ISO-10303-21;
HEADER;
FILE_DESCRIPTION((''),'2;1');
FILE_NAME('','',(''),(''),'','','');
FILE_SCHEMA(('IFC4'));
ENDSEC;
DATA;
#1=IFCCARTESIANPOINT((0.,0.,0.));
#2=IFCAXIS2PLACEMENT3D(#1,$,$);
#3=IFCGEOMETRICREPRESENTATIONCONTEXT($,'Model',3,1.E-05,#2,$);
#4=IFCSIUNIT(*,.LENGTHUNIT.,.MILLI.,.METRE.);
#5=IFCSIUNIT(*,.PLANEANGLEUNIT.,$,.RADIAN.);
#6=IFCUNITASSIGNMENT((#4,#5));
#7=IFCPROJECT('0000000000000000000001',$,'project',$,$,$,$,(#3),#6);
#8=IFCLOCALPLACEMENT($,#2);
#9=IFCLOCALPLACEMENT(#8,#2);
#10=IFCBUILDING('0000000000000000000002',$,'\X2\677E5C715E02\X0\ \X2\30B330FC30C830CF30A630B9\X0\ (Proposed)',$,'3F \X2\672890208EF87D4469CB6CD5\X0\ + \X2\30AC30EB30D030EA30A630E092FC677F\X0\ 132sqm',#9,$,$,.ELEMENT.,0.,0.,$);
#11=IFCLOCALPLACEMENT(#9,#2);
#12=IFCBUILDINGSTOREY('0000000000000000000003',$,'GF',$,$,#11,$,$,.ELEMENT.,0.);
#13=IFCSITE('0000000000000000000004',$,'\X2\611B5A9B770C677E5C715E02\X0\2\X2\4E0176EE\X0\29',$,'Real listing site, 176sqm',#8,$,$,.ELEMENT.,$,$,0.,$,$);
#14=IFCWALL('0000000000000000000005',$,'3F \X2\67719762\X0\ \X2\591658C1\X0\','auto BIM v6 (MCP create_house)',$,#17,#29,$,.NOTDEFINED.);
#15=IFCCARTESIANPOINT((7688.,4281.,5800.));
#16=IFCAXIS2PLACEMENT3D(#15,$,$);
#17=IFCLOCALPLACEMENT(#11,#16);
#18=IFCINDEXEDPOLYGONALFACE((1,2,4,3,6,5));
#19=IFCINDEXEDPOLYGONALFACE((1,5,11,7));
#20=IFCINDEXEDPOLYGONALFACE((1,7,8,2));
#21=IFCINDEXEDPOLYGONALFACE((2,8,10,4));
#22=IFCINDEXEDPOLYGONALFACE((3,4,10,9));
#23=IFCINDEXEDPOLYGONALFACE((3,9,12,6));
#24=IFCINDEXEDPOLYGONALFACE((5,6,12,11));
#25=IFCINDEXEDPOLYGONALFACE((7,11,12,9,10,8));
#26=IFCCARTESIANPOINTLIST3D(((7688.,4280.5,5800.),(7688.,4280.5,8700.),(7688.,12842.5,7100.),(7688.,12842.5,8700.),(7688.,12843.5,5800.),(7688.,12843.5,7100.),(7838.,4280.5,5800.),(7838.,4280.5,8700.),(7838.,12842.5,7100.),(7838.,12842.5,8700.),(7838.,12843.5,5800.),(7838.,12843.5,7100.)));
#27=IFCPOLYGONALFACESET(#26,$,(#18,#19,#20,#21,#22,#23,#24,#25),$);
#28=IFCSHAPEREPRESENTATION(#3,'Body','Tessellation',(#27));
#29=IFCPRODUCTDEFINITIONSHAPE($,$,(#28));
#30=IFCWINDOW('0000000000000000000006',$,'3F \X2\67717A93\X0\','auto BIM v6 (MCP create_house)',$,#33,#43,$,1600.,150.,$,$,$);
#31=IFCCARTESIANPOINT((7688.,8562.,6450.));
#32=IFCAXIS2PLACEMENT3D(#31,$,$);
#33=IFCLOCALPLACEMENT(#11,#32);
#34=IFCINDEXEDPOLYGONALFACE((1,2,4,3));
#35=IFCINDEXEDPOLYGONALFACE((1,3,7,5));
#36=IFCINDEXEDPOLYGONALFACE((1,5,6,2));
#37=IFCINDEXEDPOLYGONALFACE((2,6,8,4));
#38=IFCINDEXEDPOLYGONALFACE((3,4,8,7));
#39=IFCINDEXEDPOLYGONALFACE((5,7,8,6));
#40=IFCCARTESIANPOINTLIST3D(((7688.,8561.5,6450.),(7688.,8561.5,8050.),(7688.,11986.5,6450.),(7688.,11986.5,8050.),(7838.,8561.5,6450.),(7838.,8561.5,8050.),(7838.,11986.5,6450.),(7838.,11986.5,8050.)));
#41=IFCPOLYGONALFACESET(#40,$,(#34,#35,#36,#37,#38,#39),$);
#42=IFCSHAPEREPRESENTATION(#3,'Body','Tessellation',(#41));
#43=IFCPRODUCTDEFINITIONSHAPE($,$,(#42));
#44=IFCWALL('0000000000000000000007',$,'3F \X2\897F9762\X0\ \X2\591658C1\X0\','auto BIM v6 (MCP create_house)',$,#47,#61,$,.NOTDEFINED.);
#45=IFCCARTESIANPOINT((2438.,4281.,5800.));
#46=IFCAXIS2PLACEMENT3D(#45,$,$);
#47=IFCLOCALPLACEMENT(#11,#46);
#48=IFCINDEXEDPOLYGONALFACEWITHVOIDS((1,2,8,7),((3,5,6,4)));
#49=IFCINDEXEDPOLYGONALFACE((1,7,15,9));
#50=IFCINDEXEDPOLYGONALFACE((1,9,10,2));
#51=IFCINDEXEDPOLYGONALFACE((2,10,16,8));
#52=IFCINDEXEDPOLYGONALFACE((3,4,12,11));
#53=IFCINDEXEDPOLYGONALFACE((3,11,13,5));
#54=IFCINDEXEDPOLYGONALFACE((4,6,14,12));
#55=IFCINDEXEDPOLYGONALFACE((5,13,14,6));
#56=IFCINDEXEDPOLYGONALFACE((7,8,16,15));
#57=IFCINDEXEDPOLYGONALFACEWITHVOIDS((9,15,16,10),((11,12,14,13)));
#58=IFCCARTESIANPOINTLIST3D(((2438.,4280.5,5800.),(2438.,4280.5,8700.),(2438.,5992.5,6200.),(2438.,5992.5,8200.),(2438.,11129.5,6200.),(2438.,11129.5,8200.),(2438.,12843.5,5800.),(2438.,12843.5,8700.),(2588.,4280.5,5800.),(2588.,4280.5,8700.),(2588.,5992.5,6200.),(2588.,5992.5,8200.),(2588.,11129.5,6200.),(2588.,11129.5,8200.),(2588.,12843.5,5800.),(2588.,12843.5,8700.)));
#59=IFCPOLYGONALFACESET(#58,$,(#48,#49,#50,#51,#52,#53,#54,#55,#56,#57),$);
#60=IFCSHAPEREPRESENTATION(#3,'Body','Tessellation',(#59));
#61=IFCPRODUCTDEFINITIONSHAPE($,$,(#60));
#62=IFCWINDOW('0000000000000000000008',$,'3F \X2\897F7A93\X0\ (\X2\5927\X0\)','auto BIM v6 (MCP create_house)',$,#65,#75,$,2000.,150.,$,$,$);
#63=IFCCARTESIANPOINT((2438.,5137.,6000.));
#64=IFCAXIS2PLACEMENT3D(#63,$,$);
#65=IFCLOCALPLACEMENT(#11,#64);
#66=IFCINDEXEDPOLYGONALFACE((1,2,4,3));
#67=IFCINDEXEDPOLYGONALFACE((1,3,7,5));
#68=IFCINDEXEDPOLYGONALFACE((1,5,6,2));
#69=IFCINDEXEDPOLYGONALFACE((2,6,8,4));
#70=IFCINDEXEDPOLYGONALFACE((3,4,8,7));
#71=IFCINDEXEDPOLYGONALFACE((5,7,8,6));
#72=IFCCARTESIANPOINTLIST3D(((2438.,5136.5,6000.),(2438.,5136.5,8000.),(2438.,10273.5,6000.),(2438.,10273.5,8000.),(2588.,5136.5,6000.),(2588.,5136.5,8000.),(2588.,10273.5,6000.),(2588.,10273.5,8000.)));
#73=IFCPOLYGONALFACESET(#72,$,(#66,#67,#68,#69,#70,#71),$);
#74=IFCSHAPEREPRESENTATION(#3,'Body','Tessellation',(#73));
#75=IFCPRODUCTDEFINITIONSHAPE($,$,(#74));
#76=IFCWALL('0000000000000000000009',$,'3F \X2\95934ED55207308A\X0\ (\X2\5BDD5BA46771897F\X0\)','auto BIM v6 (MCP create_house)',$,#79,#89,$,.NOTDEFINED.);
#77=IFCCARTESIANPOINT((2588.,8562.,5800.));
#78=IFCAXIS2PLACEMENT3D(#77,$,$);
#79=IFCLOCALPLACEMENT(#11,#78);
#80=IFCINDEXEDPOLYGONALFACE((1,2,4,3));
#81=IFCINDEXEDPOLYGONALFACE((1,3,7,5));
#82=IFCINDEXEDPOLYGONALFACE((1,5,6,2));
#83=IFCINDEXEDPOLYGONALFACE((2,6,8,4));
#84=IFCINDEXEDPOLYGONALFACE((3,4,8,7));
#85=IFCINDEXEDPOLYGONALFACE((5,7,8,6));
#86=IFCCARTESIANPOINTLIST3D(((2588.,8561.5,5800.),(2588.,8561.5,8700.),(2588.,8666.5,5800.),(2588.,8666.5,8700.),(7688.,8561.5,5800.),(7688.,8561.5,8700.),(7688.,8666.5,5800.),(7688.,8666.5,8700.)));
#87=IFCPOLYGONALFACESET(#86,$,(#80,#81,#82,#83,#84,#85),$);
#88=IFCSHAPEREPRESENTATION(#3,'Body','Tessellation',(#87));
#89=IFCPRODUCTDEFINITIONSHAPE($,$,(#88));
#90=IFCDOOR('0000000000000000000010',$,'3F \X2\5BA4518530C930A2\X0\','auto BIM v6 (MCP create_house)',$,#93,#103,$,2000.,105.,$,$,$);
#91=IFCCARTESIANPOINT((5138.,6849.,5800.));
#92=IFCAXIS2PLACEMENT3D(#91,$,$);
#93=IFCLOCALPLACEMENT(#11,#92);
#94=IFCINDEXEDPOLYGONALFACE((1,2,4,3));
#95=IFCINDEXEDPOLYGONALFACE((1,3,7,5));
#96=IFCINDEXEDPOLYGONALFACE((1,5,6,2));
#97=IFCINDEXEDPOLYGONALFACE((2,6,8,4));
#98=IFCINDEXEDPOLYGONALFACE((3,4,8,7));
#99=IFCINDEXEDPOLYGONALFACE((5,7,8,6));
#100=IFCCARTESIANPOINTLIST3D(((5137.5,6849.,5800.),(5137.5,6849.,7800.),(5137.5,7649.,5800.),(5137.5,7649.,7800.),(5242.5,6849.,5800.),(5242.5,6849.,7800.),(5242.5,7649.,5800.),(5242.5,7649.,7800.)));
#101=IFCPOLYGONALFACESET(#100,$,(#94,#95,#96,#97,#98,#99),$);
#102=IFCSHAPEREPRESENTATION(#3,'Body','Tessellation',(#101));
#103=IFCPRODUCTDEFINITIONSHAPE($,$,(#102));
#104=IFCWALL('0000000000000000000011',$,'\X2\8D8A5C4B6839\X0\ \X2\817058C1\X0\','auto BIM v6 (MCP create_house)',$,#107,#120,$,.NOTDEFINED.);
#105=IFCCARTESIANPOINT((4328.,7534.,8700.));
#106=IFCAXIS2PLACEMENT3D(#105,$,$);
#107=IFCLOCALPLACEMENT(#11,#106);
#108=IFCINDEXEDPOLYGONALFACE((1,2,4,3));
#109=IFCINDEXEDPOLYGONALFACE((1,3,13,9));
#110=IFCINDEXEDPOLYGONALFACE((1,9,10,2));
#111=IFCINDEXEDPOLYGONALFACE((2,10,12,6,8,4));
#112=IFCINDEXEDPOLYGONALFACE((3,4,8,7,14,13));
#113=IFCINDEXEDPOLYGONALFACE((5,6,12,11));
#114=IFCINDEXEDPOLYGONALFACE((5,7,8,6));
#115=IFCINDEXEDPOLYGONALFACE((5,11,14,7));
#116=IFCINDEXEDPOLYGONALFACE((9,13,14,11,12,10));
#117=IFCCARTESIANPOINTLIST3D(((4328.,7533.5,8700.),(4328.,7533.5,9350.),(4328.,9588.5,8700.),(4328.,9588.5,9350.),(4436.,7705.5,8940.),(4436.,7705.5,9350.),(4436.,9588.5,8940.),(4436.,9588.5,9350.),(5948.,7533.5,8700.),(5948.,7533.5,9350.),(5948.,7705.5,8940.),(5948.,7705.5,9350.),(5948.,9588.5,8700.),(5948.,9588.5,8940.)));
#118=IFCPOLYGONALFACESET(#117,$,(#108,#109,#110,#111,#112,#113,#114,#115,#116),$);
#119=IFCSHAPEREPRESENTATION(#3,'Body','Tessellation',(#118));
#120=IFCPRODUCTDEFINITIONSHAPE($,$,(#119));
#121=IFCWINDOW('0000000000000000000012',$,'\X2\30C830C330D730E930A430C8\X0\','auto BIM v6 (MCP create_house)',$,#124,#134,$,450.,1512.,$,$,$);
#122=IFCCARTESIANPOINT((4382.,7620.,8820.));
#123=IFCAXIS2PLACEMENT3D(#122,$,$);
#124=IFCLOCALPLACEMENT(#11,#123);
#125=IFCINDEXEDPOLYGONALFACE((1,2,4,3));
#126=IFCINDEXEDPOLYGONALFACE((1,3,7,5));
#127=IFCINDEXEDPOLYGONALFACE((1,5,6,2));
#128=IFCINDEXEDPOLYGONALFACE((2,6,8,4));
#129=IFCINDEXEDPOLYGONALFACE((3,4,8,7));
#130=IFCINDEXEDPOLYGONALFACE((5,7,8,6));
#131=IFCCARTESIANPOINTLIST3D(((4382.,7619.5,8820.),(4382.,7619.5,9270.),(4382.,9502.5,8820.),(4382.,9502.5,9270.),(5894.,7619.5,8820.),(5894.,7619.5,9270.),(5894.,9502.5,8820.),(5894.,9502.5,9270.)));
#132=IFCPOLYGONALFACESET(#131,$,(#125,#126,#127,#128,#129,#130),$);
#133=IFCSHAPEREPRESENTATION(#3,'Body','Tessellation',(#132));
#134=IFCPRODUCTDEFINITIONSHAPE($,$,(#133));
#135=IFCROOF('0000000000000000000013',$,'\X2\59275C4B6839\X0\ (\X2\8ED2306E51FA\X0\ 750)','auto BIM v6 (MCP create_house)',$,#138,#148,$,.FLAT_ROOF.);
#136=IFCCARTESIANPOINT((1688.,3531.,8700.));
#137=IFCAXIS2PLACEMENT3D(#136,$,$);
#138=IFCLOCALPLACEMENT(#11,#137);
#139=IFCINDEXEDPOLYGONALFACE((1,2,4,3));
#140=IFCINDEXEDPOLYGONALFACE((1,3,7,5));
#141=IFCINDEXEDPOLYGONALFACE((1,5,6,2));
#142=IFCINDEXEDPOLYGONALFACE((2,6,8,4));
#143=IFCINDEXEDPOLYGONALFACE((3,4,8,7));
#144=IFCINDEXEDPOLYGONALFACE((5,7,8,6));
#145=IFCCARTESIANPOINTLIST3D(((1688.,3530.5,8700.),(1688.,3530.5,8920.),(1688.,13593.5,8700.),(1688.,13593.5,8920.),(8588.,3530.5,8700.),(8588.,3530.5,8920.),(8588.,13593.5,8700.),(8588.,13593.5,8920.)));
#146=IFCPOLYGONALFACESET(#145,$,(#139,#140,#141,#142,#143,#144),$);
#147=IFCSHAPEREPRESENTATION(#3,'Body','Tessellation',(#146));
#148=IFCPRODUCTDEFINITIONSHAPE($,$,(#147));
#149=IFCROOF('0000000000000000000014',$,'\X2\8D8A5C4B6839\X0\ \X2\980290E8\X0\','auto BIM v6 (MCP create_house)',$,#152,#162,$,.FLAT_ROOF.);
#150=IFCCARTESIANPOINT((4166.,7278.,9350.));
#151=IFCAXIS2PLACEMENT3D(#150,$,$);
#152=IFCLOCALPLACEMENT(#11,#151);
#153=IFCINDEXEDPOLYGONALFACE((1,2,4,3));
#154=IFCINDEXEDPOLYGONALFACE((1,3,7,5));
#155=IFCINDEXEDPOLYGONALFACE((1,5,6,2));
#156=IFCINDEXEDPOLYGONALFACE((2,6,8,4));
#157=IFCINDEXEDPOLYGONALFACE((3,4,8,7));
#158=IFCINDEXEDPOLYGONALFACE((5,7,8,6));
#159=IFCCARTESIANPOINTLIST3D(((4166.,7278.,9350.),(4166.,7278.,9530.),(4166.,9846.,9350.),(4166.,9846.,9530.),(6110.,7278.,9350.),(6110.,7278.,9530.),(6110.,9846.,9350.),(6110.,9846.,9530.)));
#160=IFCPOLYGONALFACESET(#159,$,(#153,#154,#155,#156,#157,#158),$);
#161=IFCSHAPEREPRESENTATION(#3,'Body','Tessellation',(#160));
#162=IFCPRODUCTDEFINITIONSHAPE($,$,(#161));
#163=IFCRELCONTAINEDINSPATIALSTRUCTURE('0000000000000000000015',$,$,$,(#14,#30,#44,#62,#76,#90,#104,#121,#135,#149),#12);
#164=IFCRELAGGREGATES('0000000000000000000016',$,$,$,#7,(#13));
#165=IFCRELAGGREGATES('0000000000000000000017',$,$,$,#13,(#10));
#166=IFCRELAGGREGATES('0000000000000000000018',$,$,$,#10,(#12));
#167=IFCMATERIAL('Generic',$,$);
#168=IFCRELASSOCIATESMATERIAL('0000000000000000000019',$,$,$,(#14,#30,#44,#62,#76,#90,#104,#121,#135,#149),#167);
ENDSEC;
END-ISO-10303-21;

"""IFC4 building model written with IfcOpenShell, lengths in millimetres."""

from ifc_helpers import new_model, si_unit, frame, frame_2d, origin, place, context, project, spatial, rectangle, extrude, material, element, fill, save


model = new_model("IFC4")

# Units and contexts
model_context = context("Model", 3, precision=1e-05, world=origin())
ifc_project = project(units=[si_unit("LENGTHUNIT", "METRE", prefix="MILLI"), si_unit("PLANEANGLEUNIT", "RADIAN")], contexts=[model_context])

# Site, building, storey
site_placement = place(None, origin())
site = spatial("IfcSite", under=ifc_project, at=site_placement, Name="愛媛県松山市2丁目29", ObjectType="Real listing site, 176sqm", CompositionType="ELEMENT", RefElevation=0.0)
building_placement = place(site_placement, origin())
building = spatial("IfcBuilding", under=site, at=building_placement, Name="松山市 コートハウス (Proposed)", ObjectType="3F 木造軸組構法 + ガルバリウム鋼板 132sqm", CompositionType="ELEMENT", ElevationOfRefHeight=0.0, ElevationOfTerrain=0.0)
storey_placement = place(building_placement, origin())
storey = spatial("IfcBuildingStorey", under=building, at=storey_placement, Name="GF", CompositionType="ELEMENT", Elevation=0.0)

# Shared definitions
ifc_material = material(Name="Generic")

# Walls, openings, windows
wall_1_placement = place(storey_placement, frame((7688.0, 4281.0, 5800.0)))
wall_1 = element("IfcWall", 1, at=wall_1_placement, inside=storey, material=ifc_material, Name="3F 東面 外壁", Description="auto BIM v6 (MCP create_house)", PredefinedType="NOTDEFINED", context=model_context, shape_type="SweptSolid", body=[
    extrude(rectangle(XDim=150.0, YDim=8563.0, at=frame_2d((75.0, 4281.0))), frame((7688.0, 4281.0, 5800.0)), (0.0, 0.0, 1.0), 2900.0),
])
opening_1_placement = place(storey_placement, frame((7688.0, 8562.0, 6450.0)))
opening_1 = element("IfcOpeningElement", 2, at=opening_1_placement, cuts=wall_1, PredefinedType="NOTDEFINED", context=model_context, shape_type="SweptSolid", body=[
    extrude(rectangle(XDim=150.0, YDim=3425.0, at=frame_2d((75.0, 1712.0))), frame((7688.0, 8562.0, 6450.0)), (0.0, 0.0, 1.0), 1600.0),
])
window_1_placement = place(storey_placement, frame((7688.0, 8562.0, 6450.0)))
window_1 = element("IfcWindow", 3, at=window_1_placement, inside=storey, material=ifc_material, Name="3F 東窓", Description="auto BIM v6 (MCP create_house)", OverallHeight=1600.0, OverallWidth=150.0, context=model_context, shape_type="SweptSolid", body=[
    extrude(rectangle(XDim=150.0, YDim=3425.0, at=frame_2d((75.0, 1712.0))), frame((7688.0, 8562.0, 6450.0)), (0.0, 0.0, 1.0), 1600.0),
])
fill(opening_1, window_1)
wall_2_placement = place(storey_placement, frame((2438.0, 4281.0, 5800.0)))
wall_2 = element("IfcWall", 4, at=wall_2_placement, inside=storey, material=ifc_material, Name="3F 西面 外壁", Description="auto BIM v6 (MCP create_house)", PredefinedType="NOTDEFINED", context=model_context, shape_type="SweptSolid", body=[
    extrude(rectangle(XDim=150.0, YDim=8563.0, at=frame_2d((75.0, 4281.0))), frame((2438.0, 4281.0, 5800.0)), (0.0, 0.0, 1.0), 2900.0),
])
opening_2_placement = place(storey_placement, frame((2438.0, 5137.0, 6000.0)))
opening_2 = element("IfcOpeningElement", 5, at=opening_2_placement, cuts=wall_2, PredefinedType="NOTDEFINED", context=model_context, shape_type="SweptSolid", body=[
    extrude(rectangle(XDim=150.0, YDim=5137.0, at=frame_2d((75.0, 2568.0))), frame((2438.0, 5137.0, 6000.0)), (0.0, 0.0, 1.0), 2000.0),
])
window_2_placement = place(storey_placement, frame((2438.0, 5137.0, 6000.0)))
window_2 = element("IfcWindow", 6, at=window_2_placement, inside=storey, material=ifc_material, Name="3F 西窓 (大)", Description="auto BIM v6 (MCP create_house)", OverallHeight=2000.0, OverallWidth=150.0, context=model_context, shape_type="SweptSolid", body=[
    extrude(rectangle(XDim=150.0, YDim=5137.0, at=frame_2d((75.0, 2568.0))), frame((2438.0, 5137.0, 6000.0)), (0.0, 0.0, 1.0), 2000.0),
])
fill(opening_2, window_2)

# Wall
wall_3_placement = place(storey_placement, frame((2588.0, 8562.0, 5800.0)))
element("IfcWall", 7, at=wall_3_placement, inside=storey, material=ifc_material, Name="3F 間仕切り (寝室東西)", Description="auto BIM v6 (MCP create_house)", PredefinedType="NOTDEFINED", context=model_context, shape_type="SweptSolid", body=[
    extrude(rectangle(XDim=5100.0, YDim=105.0, at=frame_2d((2550.0, 52.0))), frame((2588.0, 8562.0, 5800.0)), (0.0, 0.0, 1.0), 2900.0),
])

# Door
door_1_placement = place(storey_placement, frame((5138.0, 6849.0, 5800.0)))
element("IfcDoor", 8, at=door_1_placement, inside=storey, material=ifc_material, Name="3F 室内ドア", Description="auto BIM v6 (MCP create_house)", OverallHeight=2000.0, OverallWidth=105.0, context=model_context, shape_type="SweptSolid", body=[
    extrude(rectangle(XDim=105.0, YDim=800.0, at=frame_2d((52.0, 400.0))), frame((5138.0, 6849.0, 5800.0)), (0.0, 0.0, 1.0), 2000.0),
])

# Wall, opening, window
wall_4_placement = place(storey_placement, frame((4328.0, 7534.0, 8700.0)))
wall_4 = element("IfcWall", 9, at=wall_4_placement, inside=storey, material=ifc_material, Name="越屋根 腰壁", Description="auto BIM v6 (MCP create_house)", PredefinedType="NOTDEFINED", context=model_context, shape_type="SweptSolid", body=[
    extrude(rectangle(XDim=1620.0, YDim=2055.0, at=frame_2d((810.0, 1027.0))), frame((4328.0, 7534.0, 8700.0)), (0.0, 0.0, 1.0), 650.0),
])
opening_3_placement = place(storey_placement, frame((4382.0, 7620.0, 8820.0)))
opening_3 = element("IfcOpeningElement", 10, at=opening_3_placement, cuts=wall_4, PredefinedType="NOTDEFINED", context=model_context, shape_type="SweptSolid", body=[
    extrude(rectangle(XDim=1512.0, YDim=1883.0, at=frame_2d((756.0, 941.0))), frame((4382.0, 7620.0, 8820.0)), (0.0, 0.0, 1.0), 450.0),
])
window_3_placement = place(storey_placement, frame((4382.0, 7620.0, 8820.0)))
window_3 = element("IfcWindow", 11, at=window_3_placement, inside=storey, material=ifc_material, Name="トップライト", Description="auto BIM v6 (MCP create_house)", OverallHeight=450.0, OverallWidth=1512.0, context=model_context, shape_type="SweptSolid", body=[
    extrude(rectangle(XDim=1512.0, YDim=1883.0, at=frame_2d((756.0, 941.0))), frame((4382.0, 7620.0, 8820.0)), (0.0, 0.0, 1.0), 450.0),
])
fill(opening_3, window_3)

# Roofs
roof_1_placement = place(storey_placement, frame((1688.0, 3531.0, 8700.0)))
element("IfcRoof", 12, at=roof_1_placement, inside=storey, material=ifc_material, Name="大屋根 (軒の出 750)", Description="auto BIM v6 (MCP create_house)", PredefinedType="FLAT_ROOF", context=model_context, shape_type="SweptSolid", body=[
    extrude(rectangle(XDim=6900.0, YDim=10063.0, at=frame_2d((3450.0, 5031.0))), frame((1688.0, 3531.0, 8700.0)), (0.0, 0.0, 1.0), 220.0),
])
roof_2_placement = place(storey_placement, frame((4166.0, 7278.0, 9350.0)))
element("IfcRoof", 13, at=roof_2_placement, inside=storey, material=ifc_material, Name="越屋根 頂部", Description="auto BIM v6 (MCP create_house)", PredefinedType="FLAT_ROOF", context=model_context, shape_type="SweptSolid", body=[
    extrude(rectangle(XDim=1944.0, YDim=2568.0, at=frame_2d((972.0, 1284.0))), frame((4166.0, 7278.0, 9350.0)), (0.0, 0.0, 1.0), 180.0),
])

save(model, "model.ifc")
